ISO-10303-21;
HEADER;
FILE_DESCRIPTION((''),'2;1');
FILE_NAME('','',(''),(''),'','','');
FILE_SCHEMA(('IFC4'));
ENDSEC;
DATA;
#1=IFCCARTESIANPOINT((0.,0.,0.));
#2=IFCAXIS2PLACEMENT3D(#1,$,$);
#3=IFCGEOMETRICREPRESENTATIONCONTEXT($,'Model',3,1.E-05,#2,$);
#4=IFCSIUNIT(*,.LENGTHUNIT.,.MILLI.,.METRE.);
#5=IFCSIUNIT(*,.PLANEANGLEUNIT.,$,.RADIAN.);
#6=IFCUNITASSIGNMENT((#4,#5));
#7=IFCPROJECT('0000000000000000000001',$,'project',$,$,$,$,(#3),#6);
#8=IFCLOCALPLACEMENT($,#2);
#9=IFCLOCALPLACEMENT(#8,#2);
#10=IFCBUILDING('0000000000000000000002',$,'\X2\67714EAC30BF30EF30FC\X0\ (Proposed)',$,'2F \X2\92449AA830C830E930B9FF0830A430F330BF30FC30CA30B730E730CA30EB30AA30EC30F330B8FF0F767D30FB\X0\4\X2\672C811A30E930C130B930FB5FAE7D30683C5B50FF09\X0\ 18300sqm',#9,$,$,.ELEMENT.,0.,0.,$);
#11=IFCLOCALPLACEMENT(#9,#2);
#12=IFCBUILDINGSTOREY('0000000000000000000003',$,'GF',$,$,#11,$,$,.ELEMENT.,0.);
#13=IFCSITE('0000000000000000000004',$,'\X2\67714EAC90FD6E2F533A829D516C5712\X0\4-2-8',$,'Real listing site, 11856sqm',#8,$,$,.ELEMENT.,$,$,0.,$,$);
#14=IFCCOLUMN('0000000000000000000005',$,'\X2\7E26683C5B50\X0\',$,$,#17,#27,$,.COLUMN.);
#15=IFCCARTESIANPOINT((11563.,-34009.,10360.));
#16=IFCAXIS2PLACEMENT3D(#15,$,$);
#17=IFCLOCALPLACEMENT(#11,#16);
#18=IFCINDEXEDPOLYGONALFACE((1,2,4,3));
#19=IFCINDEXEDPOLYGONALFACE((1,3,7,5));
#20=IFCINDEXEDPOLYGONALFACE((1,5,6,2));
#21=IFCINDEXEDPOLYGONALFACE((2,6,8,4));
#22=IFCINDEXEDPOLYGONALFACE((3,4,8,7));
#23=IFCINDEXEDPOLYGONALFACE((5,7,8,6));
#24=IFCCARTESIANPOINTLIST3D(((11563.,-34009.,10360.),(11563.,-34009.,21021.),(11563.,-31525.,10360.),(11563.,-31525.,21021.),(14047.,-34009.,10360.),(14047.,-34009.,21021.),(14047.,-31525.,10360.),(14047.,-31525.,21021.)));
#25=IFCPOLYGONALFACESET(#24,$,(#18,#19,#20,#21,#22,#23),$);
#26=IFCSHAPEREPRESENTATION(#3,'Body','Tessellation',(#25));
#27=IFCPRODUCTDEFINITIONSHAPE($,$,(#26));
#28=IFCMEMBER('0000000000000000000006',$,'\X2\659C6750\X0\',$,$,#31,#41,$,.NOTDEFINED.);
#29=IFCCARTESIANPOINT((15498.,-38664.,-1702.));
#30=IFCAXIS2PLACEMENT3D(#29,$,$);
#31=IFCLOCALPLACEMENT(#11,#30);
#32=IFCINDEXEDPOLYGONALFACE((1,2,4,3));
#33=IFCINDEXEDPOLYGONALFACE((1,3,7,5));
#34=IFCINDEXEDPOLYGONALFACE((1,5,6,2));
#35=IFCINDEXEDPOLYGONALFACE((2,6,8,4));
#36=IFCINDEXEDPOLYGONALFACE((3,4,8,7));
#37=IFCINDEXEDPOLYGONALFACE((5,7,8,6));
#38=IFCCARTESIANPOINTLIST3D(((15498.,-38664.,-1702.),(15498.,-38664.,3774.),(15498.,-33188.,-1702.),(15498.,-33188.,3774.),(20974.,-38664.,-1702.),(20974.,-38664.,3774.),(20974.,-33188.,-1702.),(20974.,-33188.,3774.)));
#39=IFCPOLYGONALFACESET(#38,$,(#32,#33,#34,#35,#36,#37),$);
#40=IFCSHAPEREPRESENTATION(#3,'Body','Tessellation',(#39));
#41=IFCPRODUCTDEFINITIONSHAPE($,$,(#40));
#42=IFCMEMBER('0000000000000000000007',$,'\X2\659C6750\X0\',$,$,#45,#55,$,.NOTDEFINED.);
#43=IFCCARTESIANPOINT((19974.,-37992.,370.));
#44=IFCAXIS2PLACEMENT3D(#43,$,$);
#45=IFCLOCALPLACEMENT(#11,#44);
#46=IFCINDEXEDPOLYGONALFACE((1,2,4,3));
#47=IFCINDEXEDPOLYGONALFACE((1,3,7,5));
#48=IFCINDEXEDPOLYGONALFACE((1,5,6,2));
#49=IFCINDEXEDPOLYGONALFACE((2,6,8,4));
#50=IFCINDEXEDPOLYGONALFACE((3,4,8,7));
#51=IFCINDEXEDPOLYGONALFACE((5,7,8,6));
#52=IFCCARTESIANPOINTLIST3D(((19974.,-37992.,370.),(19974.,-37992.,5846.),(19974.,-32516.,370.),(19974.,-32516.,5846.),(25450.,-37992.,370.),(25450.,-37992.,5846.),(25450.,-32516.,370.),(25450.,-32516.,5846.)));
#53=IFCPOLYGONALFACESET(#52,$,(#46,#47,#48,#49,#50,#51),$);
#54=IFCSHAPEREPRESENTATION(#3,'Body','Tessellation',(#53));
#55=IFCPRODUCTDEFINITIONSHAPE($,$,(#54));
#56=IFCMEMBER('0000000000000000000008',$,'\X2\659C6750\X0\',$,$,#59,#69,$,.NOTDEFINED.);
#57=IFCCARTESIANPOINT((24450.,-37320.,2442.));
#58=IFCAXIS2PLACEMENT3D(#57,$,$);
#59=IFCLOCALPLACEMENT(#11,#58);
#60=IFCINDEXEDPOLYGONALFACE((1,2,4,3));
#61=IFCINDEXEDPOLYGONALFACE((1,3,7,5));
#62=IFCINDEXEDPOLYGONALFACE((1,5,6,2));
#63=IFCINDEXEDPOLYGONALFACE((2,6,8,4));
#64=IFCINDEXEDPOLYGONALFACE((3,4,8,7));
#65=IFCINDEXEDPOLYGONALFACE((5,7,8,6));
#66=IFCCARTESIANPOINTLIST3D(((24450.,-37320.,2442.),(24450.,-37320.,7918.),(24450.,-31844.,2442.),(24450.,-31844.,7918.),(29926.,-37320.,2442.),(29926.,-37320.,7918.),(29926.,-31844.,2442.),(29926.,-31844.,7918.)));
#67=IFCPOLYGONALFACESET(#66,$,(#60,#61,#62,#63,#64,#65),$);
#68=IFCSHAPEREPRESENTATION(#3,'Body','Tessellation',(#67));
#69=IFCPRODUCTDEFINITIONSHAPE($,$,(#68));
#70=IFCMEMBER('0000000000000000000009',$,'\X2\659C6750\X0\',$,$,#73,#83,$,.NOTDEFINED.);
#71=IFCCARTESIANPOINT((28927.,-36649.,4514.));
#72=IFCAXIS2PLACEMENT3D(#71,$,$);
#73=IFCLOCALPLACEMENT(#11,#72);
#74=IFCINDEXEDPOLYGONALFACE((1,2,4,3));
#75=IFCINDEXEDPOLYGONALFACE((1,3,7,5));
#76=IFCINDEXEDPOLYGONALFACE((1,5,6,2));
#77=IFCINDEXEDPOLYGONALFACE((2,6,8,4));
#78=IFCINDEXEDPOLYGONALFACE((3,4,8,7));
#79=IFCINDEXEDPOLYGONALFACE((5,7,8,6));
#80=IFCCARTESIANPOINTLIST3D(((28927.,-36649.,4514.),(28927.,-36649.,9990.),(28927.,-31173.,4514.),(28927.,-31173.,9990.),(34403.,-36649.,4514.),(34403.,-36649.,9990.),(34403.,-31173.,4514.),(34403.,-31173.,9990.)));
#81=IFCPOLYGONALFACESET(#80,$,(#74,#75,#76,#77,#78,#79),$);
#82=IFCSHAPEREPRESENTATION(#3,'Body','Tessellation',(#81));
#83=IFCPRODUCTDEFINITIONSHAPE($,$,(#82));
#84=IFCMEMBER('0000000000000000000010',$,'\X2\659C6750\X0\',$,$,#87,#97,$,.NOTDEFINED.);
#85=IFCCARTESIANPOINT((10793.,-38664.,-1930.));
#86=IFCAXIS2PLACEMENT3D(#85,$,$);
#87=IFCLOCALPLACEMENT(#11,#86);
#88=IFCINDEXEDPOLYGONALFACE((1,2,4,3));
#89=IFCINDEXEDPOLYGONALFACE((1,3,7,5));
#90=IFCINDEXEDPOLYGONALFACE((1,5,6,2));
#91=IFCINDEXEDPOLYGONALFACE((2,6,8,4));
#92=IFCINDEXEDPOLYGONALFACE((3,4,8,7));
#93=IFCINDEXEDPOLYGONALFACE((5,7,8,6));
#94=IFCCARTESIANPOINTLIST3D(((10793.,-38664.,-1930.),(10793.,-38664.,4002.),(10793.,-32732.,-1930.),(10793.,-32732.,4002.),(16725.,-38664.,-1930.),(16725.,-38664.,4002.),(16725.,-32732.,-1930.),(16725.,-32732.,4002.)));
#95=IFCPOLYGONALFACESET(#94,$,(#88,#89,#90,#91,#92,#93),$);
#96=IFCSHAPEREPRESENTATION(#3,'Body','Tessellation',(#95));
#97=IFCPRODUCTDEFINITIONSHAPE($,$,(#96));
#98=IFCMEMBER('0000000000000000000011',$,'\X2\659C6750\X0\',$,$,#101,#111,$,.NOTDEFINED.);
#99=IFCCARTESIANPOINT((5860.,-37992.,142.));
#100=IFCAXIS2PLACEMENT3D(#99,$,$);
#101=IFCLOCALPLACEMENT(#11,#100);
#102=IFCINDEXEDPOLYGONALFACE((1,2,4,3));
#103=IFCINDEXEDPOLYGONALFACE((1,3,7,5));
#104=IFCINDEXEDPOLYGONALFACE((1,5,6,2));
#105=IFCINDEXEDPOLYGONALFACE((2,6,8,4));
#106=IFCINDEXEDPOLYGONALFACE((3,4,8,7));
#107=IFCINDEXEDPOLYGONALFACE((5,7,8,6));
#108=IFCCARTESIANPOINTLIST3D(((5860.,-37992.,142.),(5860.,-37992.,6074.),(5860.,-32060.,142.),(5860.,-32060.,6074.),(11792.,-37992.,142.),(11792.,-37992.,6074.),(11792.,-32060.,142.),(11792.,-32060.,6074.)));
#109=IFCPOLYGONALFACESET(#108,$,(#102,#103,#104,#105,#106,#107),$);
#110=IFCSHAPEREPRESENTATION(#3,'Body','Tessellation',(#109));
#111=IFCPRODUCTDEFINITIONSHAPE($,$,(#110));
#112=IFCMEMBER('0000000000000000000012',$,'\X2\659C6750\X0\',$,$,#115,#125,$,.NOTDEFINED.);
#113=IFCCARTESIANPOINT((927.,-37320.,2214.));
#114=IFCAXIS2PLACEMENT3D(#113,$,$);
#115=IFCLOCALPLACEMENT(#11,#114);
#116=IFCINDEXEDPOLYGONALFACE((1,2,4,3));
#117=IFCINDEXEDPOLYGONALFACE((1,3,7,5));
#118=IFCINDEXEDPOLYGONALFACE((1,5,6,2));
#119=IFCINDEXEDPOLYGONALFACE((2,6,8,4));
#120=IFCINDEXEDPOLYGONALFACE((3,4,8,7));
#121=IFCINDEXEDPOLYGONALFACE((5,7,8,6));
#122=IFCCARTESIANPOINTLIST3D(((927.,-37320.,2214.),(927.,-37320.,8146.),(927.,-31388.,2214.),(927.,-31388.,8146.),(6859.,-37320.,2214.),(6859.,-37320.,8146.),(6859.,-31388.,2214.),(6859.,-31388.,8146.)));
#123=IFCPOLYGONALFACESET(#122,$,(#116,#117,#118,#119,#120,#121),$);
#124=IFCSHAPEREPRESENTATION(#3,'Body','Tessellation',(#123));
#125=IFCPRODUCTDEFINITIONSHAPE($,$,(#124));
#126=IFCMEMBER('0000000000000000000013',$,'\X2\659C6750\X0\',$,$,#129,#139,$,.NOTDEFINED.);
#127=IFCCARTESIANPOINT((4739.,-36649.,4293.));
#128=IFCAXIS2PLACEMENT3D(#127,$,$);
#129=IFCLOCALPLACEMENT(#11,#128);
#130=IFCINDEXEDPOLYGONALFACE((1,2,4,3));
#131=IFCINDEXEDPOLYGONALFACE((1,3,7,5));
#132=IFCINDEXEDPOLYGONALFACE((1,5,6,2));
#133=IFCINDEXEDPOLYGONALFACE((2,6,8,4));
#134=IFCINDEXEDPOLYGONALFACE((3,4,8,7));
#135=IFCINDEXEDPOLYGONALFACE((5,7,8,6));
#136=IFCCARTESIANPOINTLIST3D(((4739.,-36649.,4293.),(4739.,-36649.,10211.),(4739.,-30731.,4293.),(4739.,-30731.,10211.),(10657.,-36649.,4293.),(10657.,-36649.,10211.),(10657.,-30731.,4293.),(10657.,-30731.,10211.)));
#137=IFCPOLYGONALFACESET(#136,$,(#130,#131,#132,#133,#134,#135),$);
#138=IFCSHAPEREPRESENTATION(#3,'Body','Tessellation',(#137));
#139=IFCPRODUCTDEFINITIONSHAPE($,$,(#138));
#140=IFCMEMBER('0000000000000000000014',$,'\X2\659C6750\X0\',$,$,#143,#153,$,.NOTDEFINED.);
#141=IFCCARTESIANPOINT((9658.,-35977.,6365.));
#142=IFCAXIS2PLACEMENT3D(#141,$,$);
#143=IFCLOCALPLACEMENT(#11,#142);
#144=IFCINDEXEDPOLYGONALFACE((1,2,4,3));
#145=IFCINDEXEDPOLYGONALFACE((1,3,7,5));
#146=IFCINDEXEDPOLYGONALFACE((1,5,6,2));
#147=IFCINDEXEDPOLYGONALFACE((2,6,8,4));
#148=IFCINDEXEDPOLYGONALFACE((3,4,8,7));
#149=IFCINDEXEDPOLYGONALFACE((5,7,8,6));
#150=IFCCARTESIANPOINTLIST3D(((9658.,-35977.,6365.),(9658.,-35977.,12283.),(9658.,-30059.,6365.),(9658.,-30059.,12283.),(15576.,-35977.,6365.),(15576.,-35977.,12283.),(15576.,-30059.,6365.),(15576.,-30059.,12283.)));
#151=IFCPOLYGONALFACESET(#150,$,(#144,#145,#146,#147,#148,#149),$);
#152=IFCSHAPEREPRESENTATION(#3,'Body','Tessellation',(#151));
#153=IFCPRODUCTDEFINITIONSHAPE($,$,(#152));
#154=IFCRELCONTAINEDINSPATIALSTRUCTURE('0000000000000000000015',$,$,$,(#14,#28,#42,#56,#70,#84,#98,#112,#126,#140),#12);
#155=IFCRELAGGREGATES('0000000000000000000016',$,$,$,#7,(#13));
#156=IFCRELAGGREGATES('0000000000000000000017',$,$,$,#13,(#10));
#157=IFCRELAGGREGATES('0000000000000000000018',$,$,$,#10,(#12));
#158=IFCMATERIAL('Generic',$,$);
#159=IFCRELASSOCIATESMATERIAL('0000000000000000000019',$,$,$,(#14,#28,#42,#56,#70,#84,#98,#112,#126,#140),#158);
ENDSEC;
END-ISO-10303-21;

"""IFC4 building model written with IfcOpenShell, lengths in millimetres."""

from ifc_helpers import new_model, si_unit, frame, frame_2d, origin, place, context, project, spatial, rectangle, extrude, material, element, save


model = new_model("IFC4")

# Units and contexts
model_context = context("Model", 3, precision=1e-05, world=origin())
ifc_project = project(units=[si_unit("LENGTHUNIT", "METRE", prefix="MILLI"), si_unit("PLANEANGLEUNIT", "RADIAN")], contexts=[model_context])

# Site, building, storey
site_placement = place(None, origin())
site = spatial("IfcSite", under=ifc_project, at=site_placement, Name="東京都港区芝公園4-2-8", ObjectType="Real listing site, 11856sqm", CompositionType="ELEMENT", RefElevation=0.0)
building_placement = place(site_placement, origin())
building = spatial("IfcBuilding", under=site, at=building_placement, Name="東京タワー (Proposed)", ObjectType="2F 鉄骨トラス（インターナショナルオレンジ／白・4本脚ラチス・微細格子） 18300sqm", CompositionType="ELEMENT", ElevationOfRefHeight=0.0, ElevationOfTerrain=0.0)
storey_placement = place(building_placement, origin())
storey = spatial("IfcBuildingStorey", under=building, at=storey_placement, Name="GF", CompositionType="ELEMENT", Elevation=0.0)

# Column
ifc_material = material(Name="Generic")
column_1_placement = place(storey_placement, frame((11563.0, -34009.0, 10360.0)))
element("IfcColumn", 1, at=column_1_placement, inside=storey, material=ifc_material, Name="縦格子", PredefinedType="COLUMN", context=model_context, shape_type="SweptSolid", body=[
    extrude(rectangle(XDim=2484.0, YDim=2484.0, at=frame_2d((1242.0, 1242.0))), frame((11563.0, -34009.0, 10360.0)), (0.0, 0.0, 1.0), 10661.0),
])

# Members
member_1_placement = place(storey_placement, frame((15498.0, -38664.0, -1702.0)))
element("IfcMember", 2, at=member_1_placement, inside=storey, material=ifc_material, Name="斜材", PredefinedType="NOTDEFINED", context=model_context, shape_type="SweptSolid", body=[
    extrude(rectangle(XDim=5476.0, YDim=5476.0, at=frame_2d((2738.0, 2738.0))), frame((15498.0, -38664.0, -1702.0)), (0.0, 0.0, 1.0), 5476.0),
])
member_2_placement = place(storey_placement, frame((19974.0, -37992.0, 370.0)))
element("IfcMember", 3, at=member_2_placement, inside=storey, material=ifc_material, Name="斜材", PredefinedType="NOTDEFINED", context=model_context, shape_type="SweptSolid", body=[
    extrude(rectangle(XDim=5476.0, YDim=5476.0, at=frame_2d((2738.0, 2738.0))), frame((19974.0, -37992.0, 370.0)), (0.0, 0.0, 1.0), 5476.0),
])
member_3_placement = place(storey_placement, frame((24450.0, -37320.0, 2442.0)))
element("IfcMember", 4, at=member_3_placement, inside=storey, material=ifc_material, Name="斜材", PredefinedType="NOTDEFINED", context=model_context, shape_type="SweptSolid", body=[
    extrude(rectangle(XDim=5476.0, YDim=5476.0, at=frame_2d((2738.0, 2738.0))), frame((24450.0, -37320.0, 2442.0)), (0.0, 0.0, 1.0), 5476.0),
])
member_4_placement = place(storey_placement, frame((28927.0, -36649.0, 4514.0)))
element("IfcMember", 5, at=member_4_placement, inside=storey, material=ifc_material, Name="斜材", PredefinedType="NOTDEFINED", context=model_context, shape_type="SweptSolid", body=[
    extrude(rectangle(XDim=5476.0, YDim=5476.0, at=frame_2d((2738.0, 2738.0))), frame((28927.0, -36649.0, 4514.0)), (0.0, 0.0, 1.0), 5476.0),
])
member_5_placement = place(storey_placement, frame((10793.0, -38664.0, -1930.0)))
element("IfcMember", 6, at=member_5_placement, inside=storey, material=ifc_material, Name="斜材", PredefinedType="NOTDEFINED", context=model_context, shape_type="SweptSolid", body=[
    extrude(rectangle(XDim=5932.0, YDim=5932.0, at=frame_2d((2966.0, 2966.0))), frame((10793.0, -38664.0, -1930.0)), (0.0, 0.0, 1.0), 5932.0),
])
member_6_placement = place(storey_placement, frame((5860.0, -37992.0, 142.0)))
element("IfcMember", 7, at=member_6_placement, inside=storey, material=ifc_material, Name="斜材", PredefinedType="NOTDEFINED", context=model_context, shape_type="SweptSolid", body=[
    extrude(rectangle(XDim=5932.0, YDim=5932.0, at=frame_2d((2966.0, 2966.0))), frame((5860.0, -37992.0, 142.0)), (0.0, 0.0, 1.0), 5932.0),
])
member_7_placement = place(storey_placement, frame((927.0, -37320.0, 2214.0)))
element("IfcMember", 8, at=member_7_placement, inside=storey, material=ifc_material, Name="斜材", PredefinedType="NOTDEFINED", context=model_context, shape_type="SweptSolid", body=[
    extrude(rectangle(XDim=5932.0, YDim=5932.0, at=frame_2d((2966.0, 2966.0))), frame((927.0, -37320.0, 2214.0)), (0.0, 0.0, 1.0), 5932.0),
])
member_8_placement = place(storey_placement, frame((4739.0, -36649.0, 4293.0)))
element("IfcMember", 9, at=member_8_placement, inside=storey, material=ifc_material, Name="斜材", PredefinedType="NOTDEFINED", context=model_context, shape_type="SweptSolid", body=[
    extrude(rectangle(XDim=5918.0, YDim=5918.0, at=frame_2d((2959.0, 2959.0))), frame((4739.0, -36649.0, 4293.0)), (0.0, 0.0, 1.0), 5918.0),
])
member_9_placement = place(storey_placement, frame((9658.0, -35977.0, 6365.0)))
element("IfcMember", 10, at=member_9_placement, inside=storey, material=ifc_material, Name="斜材", PredefinedType="NOTDEFINED", context=model_context, shape_type="SweptSolid", body=[
    extrude(rectangle(XDim=5918.0, YDim=5918.0, at=frame_2d((2959.0, 2959.0))), frame((9658.0, -35977.0, 6365.0)), (0.0, 0.0, 1.0), 5918.0),
])

save(model, "model.ifc")
